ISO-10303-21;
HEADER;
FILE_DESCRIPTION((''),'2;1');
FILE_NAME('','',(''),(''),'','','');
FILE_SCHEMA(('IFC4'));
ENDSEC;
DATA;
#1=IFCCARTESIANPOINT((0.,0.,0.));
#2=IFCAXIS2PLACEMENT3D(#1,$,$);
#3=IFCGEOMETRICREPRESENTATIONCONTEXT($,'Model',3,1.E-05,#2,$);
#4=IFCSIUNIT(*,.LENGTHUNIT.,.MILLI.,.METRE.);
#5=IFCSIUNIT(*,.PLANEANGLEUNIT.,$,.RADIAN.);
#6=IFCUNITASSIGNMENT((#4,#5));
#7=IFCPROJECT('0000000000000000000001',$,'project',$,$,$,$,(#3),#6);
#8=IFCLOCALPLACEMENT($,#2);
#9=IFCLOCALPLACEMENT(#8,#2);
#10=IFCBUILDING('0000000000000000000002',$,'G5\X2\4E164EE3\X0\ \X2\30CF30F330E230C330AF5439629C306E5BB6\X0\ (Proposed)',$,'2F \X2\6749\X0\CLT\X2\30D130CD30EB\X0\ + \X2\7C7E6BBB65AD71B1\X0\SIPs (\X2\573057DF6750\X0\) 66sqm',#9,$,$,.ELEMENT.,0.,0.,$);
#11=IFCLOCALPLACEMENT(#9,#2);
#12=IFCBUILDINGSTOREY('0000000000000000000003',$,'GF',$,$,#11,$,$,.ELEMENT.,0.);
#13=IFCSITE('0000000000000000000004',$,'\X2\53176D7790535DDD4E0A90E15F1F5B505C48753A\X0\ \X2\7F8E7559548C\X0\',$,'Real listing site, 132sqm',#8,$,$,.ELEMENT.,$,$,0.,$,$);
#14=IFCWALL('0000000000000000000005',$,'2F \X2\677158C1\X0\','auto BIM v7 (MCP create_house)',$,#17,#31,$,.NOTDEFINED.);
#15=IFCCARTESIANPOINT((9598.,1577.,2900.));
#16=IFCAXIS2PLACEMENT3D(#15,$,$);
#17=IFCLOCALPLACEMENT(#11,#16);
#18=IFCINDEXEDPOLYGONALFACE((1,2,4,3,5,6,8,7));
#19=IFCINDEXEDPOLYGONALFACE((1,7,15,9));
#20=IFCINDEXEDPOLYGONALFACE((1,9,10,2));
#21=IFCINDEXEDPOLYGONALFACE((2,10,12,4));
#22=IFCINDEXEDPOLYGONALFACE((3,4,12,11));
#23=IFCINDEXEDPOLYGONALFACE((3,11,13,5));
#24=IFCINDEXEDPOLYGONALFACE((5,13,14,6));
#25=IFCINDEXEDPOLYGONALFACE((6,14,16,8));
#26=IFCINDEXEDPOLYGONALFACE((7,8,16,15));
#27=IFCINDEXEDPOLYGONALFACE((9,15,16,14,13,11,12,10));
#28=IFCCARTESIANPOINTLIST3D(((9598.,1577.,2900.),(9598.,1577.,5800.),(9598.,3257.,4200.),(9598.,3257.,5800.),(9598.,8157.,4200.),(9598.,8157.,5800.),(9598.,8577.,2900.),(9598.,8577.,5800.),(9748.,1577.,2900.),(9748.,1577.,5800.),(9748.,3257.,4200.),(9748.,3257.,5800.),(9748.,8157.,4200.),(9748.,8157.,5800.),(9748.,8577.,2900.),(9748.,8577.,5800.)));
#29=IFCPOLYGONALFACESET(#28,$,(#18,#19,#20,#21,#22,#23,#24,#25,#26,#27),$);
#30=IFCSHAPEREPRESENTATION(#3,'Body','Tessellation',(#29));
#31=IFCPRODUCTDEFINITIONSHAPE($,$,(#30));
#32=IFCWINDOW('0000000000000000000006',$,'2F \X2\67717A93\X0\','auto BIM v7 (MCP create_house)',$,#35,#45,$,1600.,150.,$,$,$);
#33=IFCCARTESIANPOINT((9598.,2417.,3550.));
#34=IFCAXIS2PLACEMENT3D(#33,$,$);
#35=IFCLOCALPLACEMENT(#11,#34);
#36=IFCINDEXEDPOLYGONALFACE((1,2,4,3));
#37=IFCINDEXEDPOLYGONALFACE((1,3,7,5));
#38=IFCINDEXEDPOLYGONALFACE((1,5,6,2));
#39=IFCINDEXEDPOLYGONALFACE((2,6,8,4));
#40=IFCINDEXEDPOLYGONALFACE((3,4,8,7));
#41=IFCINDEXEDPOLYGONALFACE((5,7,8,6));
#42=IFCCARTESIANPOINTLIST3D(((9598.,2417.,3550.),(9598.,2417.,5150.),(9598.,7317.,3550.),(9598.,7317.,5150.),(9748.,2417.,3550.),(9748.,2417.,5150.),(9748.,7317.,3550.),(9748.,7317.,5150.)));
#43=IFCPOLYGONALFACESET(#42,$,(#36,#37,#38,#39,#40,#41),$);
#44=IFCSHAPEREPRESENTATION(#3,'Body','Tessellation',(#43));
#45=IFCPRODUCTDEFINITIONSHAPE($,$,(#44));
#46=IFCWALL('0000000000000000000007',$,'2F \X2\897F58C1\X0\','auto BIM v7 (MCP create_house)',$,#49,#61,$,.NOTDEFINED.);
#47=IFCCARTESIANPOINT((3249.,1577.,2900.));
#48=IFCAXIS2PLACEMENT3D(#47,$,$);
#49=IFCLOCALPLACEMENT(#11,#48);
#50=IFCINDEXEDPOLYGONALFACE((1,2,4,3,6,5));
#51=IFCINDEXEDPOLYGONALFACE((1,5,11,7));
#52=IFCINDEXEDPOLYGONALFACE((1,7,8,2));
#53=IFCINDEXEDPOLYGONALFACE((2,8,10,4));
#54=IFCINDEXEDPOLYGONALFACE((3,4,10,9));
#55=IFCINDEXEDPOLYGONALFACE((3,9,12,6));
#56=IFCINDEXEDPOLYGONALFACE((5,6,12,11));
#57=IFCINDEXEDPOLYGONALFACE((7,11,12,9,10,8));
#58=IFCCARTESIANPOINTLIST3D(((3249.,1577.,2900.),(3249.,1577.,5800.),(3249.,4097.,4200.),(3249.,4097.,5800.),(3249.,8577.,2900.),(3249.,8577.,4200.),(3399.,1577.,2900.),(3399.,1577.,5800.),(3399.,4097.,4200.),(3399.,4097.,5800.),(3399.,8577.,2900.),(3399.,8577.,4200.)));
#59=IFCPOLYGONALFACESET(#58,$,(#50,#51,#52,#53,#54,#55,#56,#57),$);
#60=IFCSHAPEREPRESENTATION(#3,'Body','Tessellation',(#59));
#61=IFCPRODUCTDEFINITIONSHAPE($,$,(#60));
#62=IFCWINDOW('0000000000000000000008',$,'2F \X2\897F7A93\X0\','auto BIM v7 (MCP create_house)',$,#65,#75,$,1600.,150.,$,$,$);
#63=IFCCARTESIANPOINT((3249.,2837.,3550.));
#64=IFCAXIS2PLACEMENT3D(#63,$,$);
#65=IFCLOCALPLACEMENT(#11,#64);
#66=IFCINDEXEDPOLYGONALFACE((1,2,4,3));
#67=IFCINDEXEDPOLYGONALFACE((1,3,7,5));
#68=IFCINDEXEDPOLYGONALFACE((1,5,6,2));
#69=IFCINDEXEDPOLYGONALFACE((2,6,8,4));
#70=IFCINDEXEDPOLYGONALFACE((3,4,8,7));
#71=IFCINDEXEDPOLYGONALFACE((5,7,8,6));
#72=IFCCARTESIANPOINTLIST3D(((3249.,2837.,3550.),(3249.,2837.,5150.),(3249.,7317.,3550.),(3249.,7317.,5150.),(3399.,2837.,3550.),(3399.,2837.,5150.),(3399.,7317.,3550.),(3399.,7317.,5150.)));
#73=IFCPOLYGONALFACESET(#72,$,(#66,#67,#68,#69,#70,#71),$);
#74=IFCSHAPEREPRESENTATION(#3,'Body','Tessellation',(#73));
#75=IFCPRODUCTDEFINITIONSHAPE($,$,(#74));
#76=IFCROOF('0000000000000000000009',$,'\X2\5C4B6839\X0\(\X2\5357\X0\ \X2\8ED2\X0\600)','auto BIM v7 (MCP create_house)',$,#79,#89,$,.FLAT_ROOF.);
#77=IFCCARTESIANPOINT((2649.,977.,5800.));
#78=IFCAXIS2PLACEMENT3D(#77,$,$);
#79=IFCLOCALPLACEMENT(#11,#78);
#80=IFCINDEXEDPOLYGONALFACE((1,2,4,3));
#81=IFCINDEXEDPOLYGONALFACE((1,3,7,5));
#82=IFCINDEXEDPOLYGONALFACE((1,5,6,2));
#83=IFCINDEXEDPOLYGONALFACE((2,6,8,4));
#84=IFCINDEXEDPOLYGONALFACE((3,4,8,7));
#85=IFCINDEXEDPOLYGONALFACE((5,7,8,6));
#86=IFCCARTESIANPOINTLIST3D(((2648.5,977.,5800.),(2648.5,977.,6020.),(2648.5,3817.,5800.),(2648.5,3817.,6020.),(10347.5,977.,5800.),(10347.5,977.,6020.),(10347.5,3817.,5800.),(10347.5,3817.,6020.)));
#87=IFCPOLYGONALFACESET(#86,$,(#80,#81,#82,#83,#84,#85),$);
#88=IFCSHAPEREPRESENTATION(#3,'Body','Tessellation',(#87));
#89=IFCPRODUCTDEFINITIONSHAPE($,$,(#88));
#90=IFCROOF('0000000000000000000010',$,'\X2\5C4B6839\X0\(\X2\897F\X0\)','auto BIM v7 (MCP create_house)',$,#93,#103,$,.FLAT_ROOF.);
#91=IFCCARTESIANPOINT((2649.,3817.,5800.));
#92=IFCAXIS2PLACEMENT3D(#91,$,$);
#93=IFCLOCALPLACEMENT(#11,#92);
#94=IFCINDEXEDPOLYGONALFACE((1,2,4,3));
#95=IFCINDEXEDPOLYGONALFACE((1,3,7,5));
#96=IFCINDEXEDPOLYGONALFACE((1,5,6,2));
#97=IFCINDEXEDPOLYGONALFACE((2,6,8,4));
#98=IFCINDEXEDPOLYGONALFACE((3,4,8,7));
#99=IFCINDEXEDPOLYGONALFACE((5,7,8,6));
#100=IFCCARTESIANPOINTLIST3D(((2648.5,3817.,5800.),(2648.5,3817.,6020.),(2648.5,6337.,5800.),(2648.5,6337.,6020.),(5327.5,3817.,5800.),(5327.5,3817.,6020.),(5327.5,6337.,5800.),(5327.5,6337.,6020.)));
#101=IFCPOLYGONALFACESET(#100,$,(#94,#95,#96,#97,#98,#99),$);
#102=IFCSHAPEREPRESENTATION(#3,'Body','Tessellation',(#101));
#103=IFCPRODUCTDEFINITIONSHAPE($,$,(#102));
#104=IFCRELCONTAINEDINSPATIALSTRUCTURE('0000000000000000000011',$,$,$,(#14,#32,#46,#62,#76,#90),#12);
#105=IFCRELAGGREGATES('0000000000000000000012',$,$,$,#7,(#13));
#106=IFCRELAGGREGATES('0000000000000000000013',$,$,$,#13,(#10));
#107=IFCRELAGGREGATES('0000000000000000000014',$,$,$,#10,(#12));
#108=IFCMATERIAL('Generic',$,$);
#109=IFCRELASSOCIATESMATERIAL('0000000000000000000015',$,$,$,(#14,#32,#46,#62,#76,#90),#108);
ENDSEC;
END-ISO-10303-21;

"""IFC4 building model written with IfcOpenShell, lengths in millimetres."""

from ifc_helpers import new_model, si_unit, frame, frame_2d, origin, place, context, project, spatial, rectangle, extrude, material, element, fill, save


model = new_model("IFC4")

# Units and contexts
model_context = context("Model", 3, precision=1e-05, world=origin())
ifc_project = project(units=[si_unit("LENGTHUNIT", "METRE", prefix="MILLI"), si_unit("PLANEANGLEUNIT", "RADIAN")], contexts=[model_context])

# Site, building, storey
site_placement = place(None, origin())
site = spatial("IfcSite", under=ifc_project, at=site_placement, Name="北海道川上郡弟子屈町 美留和", ObjectType="Real listing site, 132sqm", CompositionType="ELEMENT", RefElevation=0.0)
building_placement = place(site_placement, origin())
building = spatial("IfcBuilding", under=site, at=building_placement, Name="G5世代 ハンモック吹抜の家 (Proposed)", ObjectType="2F 杉CLTパネル + 籾殻断熱SIPs (地域材) 66sqm", CompositionType="ELEMENT", ElevationOfRefHeight=0.0, ElevationOfTerrain=0.0)
storey_placement = place(building_placement, origin())
storey = spatial("IfcBuildingStorey", under=building, at=storey_placement, Name="GF", CompositionType="ELEMENT", Elevation=0.0)

# Shared definitions
ifc_material = material(Name="Generic")

# Walls, openings, windows
wall_1_placement = place(storey_placement, frame((9598.0, 1577.0, 2900.0)))
wall_1 = element("IfcWall", 1, at=wall_1_placement, inside=storey, material=ifc_material, Name="2F 東壁", Description="auto BIM v7 (MCP create_house)", PredefinedType="NOTDEFINED", context=model_context, shape_type="SweptSolid", body=[
    extrude(rectangle(XDim=150.0, YDim=7000.0, at=frame_2d((75.0, 3500.0))), frame((9598.0, 1577.0, 2900.0)), (0.0, 0.0, 1.0), 2900.0),
])
opening_1_placement = place(storey_placement, frame((9598.0, 2417.0, 3550.0)))
opening_1 = element("IfcOpeningElement", 2, at=opening_1_placement, cuts=wall_1, PredefinedType="NOTDEFINED", context=model_context, shape_type="SweptSolid", body=[
    extrude(rectangle(XDim=150.0, YDim=4900.0, at=frame_2d((75.0, 2450.0))), frame((9598.0, 2417.0, 3550.0)), (0.0, 0.0, 1.0), 1600.0),
])
window_1_placement = place(storey_placement, frame((9598.0, 2417.0, 3550.0)))
window_1 = element("IfcWindow", 3, at=window_1_placement, inside=storey, material=ifc_material, Name="2F 東窓", Description="auto BIM v7 (MCP create_house)", OverallHeight=1600.0, OverallWidth=150.0, context=model_context, shape_type="SweptSolid", body=[
    extrude(rectangle(XDim=150.0, YDim=4900.0, at=frame_2d((75.0, 2450.0))), frame((9598.0, 2417.0, 3550.0)), (0.0, 0.0, 1.0), 1600.0),
])
fill(opening_1, window_1)
wall_2_placement = place(storey_placement, frame((3249.0, 1577.0, 2900.0)))
wall_2 = element("IfcWall", 4, at=wall_2_placement, inside=storey, material=ifc_material, Name="2F 西壁", Description="auto BIM v7 (MCP create_house)", PredefinedType="NOTDEFINED", context=model_context, shape_type="SweptSolid", body=[
    extrude(rectangle(XDim=150.0, YDim=7000.0, at=frame_2d((75.0, 3500.0))), frame((3249.0, 1577.0, 2900.0)), (0.0, 0.0, 1.0), 2900.0),
])
opening_2_placement = place(storey_placement, frame((3249.0, 2837.0, 3550.0)))
opening_2 = element("IfcOpeningElement", 5, at=opening_2_placement, cuts=wall_2, PredefinedType="NOTDEFINED", context=model_context, shape_type="SweptSolid", body=[
    extrude(rectangle(XDim=150.0, YDim=4480.0, at=frame_2d((75.0, 2240.0))), frame((3249.0, 2837.0, 3550.0)), (0.0, 0.0, 1.0), 1600.0),
])
window_2_placement = place(storey_placement, frame((3249.0, 2837.0, 3550.0)))
window_2 = element("IfcWindow", 6, at=window_2_placement, inside=storey, material=ifc_material, Name="2F 西窓", Description="auto BIM v7 (MCP create_house)", OverallHeight=1600.0, OverallWidth=150.0, context=model_context, shape_type="SweptSolid", body=[
    extrude(rectangle(XDim=150.0, YDim=4480.0, at=frame_2d((75.0, 2240.0))), frame((3249.0, 2837.0, 3550.0)), (0.0, 0.0, 1.0), 1600.0),
])
fill(opening_2, window_2)

# Roofs
roof_1_placement = place(storey_placement, frame((2649.0, 977.0, 5800.0)))
element("IfcRoof", 7, at=roof_1_placement, inside=storey, material=ifc_material, Name="屋根(南 軒600)", Description="auto BIM v7 (MCP create_house)", PredefinedType="FLAT_ROOF", context=model_context, shape_type="SweptSolid", body=[
    extrude(rectangle(XDim=7699.0, YDim=2840.0, at=frame_2d((3849.0, 1420.0))), frame((2649.0, 977.0, 5800.0)), (0.0, 0.0, 1.0), 220.0),
])
roof_2_placement = place(storey_placement, frame((2649.0, 3817.0, 5800.0)))
element("IfcRoof", 8, at=roof_2_placement, inside=storey, material=ifc_material, Name="屋根(西)", Description="auto BIM v7 (MCP create_house)", PredefinedType="FLAT_ROOF", context=model_context, shape_type="SweptSolid", body=[
    extrude(rectangle(XDim=2679.0, YDim=2520.0, at=frame_2d((1339.0, 1260.0))), frame((2649.0, 3817.0, 5800.0)), (0.0, 0.0, 1.0), 220.0),
])

save(model, "model.ifc")
